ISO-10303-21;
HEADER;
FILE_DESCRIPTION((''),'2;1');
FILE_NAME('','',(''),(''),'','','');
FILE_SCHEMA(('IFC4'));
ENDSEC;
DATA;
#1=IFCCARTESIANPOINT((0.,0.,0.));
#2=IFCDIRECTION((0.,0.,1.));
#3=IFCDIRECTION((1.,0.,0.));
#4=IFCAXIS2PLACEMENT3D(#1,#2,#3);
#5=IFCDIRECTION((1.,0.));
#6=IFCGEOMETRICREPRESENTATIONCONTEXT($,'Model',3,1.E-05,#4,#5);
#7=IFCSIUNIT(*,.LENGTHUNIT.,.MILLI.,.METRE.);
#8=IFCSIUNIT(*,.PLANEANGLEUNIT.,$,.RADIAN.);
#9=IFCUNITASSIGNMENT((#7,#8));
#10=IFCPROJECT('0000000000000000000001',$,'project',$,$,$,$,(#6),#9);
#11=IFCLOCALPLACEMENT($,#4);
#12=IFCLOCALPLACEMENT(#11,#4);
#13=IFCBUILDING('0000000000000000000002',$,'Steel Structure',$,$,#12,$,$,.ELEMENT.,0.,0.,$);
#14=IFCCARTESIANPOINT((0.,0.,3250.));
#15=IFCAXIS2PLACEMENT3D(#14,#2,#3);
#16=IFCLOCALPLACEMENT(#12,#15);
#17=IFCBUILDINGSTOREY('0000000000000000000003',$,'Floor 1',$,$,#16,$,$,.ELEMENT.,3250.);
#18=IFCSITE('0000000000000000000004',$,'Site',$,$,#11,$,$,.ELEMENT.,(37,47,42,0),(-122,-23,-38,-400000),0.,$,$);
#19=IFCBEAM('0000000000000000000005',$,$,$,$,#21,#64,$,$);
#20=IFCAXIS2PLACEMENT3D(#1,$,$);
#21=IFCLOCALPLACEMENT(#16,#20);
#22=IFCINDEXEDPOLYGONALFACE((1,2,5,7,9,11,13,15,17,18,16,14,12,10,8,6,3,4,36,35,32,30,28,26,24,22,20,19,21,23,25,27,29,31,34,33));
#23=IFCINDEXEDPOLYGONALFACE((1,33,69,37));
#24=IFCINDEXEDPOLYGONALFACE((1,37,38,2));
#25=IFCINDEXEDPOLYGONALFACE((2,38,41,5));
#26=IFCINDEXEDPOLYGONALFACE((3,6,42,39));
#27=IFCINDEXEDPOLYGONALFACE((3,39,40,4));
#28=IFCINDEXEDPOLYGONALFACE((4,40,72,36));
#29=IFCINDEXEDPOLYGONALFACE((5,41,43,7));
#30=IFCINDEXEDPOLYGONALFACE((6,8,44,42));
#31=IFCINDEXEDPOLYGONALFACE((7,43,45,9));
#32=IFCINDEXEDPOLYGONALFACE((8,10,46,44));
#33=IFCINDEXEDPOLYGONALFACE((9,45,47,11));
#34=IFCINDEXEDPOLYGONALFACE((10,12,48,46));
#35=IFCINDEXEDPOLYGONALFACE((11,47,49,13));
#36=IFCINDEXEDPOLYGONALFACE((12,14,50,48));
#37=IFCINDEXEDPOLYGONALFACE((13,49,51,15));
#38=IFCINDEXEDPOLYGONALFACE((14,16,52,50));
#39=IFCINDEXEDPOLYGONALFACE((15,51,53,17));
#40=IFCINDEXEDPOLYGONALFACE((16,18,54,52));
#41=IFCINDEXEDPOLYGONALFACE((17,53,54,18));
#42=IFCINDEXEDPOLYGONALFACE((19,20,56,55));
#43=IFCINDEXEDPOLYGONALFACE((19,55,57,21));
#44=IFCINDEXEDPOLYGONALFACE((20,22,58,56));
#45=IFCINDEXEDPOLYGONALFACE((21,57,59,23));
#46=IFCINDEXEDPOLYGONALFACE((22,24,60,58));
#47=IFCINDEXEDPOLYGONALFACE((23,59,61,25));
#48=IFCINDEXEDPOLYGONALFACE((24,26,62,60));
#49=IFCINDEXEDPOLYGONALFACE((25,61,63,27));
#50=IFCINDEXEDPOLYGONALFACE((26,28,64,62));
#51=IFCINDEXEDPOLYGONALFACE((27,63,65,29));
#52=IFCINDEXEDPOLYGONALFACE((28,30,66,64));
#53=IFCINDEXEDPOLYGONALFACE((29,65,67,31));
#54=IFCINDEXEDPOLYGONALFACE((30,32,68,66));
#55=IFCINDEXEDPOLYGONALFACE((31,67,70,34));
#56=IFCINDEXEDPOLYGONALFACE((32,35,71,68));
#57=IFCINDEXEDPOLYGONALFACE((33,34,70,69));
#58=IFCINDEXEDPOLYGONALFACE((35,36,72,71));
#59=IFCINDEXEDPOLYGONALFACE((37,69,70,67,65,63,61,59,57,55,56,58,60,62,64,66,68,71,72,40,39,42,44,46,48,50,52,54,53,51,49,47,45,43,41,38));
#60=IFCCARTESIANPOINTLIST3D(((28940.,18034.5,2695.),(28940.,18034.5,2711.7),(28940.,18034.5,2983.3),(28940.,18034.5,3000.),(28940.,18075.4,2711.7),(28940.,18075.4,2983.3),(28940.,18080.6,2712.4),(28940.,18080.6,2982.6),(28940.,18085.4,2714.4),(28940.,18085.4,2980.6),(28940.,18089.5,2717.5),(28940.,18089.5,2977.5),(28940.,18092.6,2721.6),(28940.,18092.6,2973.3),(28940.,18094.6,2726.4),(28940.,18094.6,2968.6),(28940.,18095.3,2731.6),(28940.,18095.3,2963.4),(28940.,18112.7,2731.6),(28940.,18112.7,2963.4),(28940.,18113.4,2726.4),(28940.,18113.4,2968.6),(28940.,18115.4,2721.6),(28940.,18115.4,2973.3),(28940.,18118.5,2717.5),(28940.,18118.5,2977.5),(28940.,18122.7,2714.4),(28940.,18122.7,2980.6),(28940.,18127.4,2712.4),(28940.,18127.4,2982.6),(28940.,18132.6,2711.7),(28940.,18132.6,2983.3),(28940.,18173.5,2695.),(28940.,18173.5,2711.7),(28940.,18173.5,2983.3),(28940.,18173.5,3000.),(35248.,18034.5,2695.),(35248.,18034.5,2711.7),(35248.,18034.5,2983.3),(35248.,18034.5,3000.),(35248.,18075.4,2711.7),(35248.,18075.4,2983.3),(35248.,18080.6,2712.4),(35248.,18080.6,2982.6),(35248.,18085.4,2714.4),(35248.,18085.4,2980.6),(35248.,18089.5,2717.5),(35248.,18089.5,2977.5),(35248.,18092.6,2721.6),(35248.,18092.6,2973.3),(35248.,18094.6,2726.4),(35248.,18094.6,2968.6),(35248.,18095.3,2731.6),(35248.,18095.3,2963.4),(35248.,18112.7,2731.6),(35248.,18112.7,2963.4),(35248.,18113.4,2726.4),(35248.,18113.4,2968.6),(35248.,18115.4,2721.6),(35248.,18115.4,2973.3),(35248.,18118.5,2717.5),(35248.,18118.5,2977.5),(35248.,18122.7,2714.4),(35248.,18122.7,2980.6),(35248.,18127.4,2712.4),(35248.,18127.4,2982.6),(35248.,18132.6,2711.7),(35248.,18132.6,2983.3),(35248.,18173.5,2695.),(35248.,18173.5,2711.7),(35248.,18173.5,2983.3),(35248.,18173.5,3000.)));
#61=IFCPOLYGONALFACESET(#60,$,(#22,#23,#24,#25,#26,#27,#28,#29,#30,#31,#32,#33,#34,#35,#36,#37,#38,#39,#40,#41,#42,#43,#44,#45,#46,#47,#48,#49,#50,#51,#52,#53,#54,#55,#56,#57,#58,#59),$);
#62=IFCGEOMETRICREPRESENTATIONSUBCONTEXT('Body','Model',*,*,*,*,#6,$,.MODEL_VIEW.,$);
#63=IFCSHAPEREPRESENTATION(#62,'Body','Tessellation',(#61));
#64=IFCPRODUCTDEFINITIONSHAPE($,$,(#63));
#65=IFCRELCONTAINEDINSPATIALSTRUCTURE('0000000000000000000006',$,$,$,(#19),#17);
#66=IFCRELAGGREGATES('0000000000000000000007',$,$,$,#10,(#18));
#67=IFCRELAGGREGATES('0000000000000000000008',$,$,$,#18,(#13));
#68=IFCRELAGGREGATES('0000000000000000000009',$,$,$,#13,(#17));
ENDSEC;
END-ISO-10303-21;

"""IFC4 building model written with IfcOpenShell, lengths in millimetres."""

from ifc_helpers import new_model, si_unit, direction, frame, origin_with_axes, origin_2d_with_axis, place, context, subcontext, project, spatial, i_section, extrude, element, save


model = new_model("IFC4")

# Units and contexts
model_context = context("Model", 3, precision=1e-05, world=origin_with_axes(), true_north=direction((1.0, 0.0)))
body_context = subcontext(model_context, "Body", "Model", "MODEL_VIEW")
ifc_project = project(units=[si_unit("LENGTHUNIT", "METRE", prefix="MILLI"), si_unit("PLANEANGLEUNIT", "RADIAN")], contexts=[model_context])

# Site, building, storey
site_placement = place(None, origin_with_axes())
site = spatial("IfcSite", under=ifc_project, at=site_placement, Name="Site", CompositionType="ELEMENT", RefLatitude=(37, 47, 42, 0), RefLongitude=(-122, -23, -38, -400000), RefElevation=0.0)
building_placement = place(site_placement, origin_with_axes())
building = spatial("IfcBuilding", under=site, at=building_placement, Name="Steel Structure", CompositionType="ELEMENT", ElevationOfRefHeight=0.0, ElevationOfTerrain=0.0)
storey_placement = place(building_placement, frame((0.0, 0.0, 3250.0), z_axis=(0.0, 0.0, 1.0), x_axis=(1.0, 0.0, 0.0)))
storey = spatial("IfcBuildingStorey", under=building, at=storey_placement, Name="Floor 1", CompositionType="ELEMENT", Elevation=3250.0)

# Beam
for number, where, z_axis, x_axis in (
    (1, (35248.0, 18104.0, 2695.0), (-1.0, 0.0, 0.0), (0.0, -1.0, 0.0)),
):
    element("IfcBeam", number, at=place(storey_placement, frame(where, z_axis=z_axis, x_axis=x_axis)), inside=storey, context=body_context, shape_type="SweptSolid", body=[
        extrude(i_section(OverallWidth=139.0, OverallDepth=305.0, WebThickness=17.4, FlangeThickness=16.7, FilletRadius=19.9, at=origin_2d_with_axis()), frame((0.0, 152.5, 0.0), z_axis=(0.0, 0.0, 1.0), x_axis=(1.0, 0.0, 0.0)), (0.0, 0.0, 1.0), 6308.0),
    ])

save(model, "model.ifc")
